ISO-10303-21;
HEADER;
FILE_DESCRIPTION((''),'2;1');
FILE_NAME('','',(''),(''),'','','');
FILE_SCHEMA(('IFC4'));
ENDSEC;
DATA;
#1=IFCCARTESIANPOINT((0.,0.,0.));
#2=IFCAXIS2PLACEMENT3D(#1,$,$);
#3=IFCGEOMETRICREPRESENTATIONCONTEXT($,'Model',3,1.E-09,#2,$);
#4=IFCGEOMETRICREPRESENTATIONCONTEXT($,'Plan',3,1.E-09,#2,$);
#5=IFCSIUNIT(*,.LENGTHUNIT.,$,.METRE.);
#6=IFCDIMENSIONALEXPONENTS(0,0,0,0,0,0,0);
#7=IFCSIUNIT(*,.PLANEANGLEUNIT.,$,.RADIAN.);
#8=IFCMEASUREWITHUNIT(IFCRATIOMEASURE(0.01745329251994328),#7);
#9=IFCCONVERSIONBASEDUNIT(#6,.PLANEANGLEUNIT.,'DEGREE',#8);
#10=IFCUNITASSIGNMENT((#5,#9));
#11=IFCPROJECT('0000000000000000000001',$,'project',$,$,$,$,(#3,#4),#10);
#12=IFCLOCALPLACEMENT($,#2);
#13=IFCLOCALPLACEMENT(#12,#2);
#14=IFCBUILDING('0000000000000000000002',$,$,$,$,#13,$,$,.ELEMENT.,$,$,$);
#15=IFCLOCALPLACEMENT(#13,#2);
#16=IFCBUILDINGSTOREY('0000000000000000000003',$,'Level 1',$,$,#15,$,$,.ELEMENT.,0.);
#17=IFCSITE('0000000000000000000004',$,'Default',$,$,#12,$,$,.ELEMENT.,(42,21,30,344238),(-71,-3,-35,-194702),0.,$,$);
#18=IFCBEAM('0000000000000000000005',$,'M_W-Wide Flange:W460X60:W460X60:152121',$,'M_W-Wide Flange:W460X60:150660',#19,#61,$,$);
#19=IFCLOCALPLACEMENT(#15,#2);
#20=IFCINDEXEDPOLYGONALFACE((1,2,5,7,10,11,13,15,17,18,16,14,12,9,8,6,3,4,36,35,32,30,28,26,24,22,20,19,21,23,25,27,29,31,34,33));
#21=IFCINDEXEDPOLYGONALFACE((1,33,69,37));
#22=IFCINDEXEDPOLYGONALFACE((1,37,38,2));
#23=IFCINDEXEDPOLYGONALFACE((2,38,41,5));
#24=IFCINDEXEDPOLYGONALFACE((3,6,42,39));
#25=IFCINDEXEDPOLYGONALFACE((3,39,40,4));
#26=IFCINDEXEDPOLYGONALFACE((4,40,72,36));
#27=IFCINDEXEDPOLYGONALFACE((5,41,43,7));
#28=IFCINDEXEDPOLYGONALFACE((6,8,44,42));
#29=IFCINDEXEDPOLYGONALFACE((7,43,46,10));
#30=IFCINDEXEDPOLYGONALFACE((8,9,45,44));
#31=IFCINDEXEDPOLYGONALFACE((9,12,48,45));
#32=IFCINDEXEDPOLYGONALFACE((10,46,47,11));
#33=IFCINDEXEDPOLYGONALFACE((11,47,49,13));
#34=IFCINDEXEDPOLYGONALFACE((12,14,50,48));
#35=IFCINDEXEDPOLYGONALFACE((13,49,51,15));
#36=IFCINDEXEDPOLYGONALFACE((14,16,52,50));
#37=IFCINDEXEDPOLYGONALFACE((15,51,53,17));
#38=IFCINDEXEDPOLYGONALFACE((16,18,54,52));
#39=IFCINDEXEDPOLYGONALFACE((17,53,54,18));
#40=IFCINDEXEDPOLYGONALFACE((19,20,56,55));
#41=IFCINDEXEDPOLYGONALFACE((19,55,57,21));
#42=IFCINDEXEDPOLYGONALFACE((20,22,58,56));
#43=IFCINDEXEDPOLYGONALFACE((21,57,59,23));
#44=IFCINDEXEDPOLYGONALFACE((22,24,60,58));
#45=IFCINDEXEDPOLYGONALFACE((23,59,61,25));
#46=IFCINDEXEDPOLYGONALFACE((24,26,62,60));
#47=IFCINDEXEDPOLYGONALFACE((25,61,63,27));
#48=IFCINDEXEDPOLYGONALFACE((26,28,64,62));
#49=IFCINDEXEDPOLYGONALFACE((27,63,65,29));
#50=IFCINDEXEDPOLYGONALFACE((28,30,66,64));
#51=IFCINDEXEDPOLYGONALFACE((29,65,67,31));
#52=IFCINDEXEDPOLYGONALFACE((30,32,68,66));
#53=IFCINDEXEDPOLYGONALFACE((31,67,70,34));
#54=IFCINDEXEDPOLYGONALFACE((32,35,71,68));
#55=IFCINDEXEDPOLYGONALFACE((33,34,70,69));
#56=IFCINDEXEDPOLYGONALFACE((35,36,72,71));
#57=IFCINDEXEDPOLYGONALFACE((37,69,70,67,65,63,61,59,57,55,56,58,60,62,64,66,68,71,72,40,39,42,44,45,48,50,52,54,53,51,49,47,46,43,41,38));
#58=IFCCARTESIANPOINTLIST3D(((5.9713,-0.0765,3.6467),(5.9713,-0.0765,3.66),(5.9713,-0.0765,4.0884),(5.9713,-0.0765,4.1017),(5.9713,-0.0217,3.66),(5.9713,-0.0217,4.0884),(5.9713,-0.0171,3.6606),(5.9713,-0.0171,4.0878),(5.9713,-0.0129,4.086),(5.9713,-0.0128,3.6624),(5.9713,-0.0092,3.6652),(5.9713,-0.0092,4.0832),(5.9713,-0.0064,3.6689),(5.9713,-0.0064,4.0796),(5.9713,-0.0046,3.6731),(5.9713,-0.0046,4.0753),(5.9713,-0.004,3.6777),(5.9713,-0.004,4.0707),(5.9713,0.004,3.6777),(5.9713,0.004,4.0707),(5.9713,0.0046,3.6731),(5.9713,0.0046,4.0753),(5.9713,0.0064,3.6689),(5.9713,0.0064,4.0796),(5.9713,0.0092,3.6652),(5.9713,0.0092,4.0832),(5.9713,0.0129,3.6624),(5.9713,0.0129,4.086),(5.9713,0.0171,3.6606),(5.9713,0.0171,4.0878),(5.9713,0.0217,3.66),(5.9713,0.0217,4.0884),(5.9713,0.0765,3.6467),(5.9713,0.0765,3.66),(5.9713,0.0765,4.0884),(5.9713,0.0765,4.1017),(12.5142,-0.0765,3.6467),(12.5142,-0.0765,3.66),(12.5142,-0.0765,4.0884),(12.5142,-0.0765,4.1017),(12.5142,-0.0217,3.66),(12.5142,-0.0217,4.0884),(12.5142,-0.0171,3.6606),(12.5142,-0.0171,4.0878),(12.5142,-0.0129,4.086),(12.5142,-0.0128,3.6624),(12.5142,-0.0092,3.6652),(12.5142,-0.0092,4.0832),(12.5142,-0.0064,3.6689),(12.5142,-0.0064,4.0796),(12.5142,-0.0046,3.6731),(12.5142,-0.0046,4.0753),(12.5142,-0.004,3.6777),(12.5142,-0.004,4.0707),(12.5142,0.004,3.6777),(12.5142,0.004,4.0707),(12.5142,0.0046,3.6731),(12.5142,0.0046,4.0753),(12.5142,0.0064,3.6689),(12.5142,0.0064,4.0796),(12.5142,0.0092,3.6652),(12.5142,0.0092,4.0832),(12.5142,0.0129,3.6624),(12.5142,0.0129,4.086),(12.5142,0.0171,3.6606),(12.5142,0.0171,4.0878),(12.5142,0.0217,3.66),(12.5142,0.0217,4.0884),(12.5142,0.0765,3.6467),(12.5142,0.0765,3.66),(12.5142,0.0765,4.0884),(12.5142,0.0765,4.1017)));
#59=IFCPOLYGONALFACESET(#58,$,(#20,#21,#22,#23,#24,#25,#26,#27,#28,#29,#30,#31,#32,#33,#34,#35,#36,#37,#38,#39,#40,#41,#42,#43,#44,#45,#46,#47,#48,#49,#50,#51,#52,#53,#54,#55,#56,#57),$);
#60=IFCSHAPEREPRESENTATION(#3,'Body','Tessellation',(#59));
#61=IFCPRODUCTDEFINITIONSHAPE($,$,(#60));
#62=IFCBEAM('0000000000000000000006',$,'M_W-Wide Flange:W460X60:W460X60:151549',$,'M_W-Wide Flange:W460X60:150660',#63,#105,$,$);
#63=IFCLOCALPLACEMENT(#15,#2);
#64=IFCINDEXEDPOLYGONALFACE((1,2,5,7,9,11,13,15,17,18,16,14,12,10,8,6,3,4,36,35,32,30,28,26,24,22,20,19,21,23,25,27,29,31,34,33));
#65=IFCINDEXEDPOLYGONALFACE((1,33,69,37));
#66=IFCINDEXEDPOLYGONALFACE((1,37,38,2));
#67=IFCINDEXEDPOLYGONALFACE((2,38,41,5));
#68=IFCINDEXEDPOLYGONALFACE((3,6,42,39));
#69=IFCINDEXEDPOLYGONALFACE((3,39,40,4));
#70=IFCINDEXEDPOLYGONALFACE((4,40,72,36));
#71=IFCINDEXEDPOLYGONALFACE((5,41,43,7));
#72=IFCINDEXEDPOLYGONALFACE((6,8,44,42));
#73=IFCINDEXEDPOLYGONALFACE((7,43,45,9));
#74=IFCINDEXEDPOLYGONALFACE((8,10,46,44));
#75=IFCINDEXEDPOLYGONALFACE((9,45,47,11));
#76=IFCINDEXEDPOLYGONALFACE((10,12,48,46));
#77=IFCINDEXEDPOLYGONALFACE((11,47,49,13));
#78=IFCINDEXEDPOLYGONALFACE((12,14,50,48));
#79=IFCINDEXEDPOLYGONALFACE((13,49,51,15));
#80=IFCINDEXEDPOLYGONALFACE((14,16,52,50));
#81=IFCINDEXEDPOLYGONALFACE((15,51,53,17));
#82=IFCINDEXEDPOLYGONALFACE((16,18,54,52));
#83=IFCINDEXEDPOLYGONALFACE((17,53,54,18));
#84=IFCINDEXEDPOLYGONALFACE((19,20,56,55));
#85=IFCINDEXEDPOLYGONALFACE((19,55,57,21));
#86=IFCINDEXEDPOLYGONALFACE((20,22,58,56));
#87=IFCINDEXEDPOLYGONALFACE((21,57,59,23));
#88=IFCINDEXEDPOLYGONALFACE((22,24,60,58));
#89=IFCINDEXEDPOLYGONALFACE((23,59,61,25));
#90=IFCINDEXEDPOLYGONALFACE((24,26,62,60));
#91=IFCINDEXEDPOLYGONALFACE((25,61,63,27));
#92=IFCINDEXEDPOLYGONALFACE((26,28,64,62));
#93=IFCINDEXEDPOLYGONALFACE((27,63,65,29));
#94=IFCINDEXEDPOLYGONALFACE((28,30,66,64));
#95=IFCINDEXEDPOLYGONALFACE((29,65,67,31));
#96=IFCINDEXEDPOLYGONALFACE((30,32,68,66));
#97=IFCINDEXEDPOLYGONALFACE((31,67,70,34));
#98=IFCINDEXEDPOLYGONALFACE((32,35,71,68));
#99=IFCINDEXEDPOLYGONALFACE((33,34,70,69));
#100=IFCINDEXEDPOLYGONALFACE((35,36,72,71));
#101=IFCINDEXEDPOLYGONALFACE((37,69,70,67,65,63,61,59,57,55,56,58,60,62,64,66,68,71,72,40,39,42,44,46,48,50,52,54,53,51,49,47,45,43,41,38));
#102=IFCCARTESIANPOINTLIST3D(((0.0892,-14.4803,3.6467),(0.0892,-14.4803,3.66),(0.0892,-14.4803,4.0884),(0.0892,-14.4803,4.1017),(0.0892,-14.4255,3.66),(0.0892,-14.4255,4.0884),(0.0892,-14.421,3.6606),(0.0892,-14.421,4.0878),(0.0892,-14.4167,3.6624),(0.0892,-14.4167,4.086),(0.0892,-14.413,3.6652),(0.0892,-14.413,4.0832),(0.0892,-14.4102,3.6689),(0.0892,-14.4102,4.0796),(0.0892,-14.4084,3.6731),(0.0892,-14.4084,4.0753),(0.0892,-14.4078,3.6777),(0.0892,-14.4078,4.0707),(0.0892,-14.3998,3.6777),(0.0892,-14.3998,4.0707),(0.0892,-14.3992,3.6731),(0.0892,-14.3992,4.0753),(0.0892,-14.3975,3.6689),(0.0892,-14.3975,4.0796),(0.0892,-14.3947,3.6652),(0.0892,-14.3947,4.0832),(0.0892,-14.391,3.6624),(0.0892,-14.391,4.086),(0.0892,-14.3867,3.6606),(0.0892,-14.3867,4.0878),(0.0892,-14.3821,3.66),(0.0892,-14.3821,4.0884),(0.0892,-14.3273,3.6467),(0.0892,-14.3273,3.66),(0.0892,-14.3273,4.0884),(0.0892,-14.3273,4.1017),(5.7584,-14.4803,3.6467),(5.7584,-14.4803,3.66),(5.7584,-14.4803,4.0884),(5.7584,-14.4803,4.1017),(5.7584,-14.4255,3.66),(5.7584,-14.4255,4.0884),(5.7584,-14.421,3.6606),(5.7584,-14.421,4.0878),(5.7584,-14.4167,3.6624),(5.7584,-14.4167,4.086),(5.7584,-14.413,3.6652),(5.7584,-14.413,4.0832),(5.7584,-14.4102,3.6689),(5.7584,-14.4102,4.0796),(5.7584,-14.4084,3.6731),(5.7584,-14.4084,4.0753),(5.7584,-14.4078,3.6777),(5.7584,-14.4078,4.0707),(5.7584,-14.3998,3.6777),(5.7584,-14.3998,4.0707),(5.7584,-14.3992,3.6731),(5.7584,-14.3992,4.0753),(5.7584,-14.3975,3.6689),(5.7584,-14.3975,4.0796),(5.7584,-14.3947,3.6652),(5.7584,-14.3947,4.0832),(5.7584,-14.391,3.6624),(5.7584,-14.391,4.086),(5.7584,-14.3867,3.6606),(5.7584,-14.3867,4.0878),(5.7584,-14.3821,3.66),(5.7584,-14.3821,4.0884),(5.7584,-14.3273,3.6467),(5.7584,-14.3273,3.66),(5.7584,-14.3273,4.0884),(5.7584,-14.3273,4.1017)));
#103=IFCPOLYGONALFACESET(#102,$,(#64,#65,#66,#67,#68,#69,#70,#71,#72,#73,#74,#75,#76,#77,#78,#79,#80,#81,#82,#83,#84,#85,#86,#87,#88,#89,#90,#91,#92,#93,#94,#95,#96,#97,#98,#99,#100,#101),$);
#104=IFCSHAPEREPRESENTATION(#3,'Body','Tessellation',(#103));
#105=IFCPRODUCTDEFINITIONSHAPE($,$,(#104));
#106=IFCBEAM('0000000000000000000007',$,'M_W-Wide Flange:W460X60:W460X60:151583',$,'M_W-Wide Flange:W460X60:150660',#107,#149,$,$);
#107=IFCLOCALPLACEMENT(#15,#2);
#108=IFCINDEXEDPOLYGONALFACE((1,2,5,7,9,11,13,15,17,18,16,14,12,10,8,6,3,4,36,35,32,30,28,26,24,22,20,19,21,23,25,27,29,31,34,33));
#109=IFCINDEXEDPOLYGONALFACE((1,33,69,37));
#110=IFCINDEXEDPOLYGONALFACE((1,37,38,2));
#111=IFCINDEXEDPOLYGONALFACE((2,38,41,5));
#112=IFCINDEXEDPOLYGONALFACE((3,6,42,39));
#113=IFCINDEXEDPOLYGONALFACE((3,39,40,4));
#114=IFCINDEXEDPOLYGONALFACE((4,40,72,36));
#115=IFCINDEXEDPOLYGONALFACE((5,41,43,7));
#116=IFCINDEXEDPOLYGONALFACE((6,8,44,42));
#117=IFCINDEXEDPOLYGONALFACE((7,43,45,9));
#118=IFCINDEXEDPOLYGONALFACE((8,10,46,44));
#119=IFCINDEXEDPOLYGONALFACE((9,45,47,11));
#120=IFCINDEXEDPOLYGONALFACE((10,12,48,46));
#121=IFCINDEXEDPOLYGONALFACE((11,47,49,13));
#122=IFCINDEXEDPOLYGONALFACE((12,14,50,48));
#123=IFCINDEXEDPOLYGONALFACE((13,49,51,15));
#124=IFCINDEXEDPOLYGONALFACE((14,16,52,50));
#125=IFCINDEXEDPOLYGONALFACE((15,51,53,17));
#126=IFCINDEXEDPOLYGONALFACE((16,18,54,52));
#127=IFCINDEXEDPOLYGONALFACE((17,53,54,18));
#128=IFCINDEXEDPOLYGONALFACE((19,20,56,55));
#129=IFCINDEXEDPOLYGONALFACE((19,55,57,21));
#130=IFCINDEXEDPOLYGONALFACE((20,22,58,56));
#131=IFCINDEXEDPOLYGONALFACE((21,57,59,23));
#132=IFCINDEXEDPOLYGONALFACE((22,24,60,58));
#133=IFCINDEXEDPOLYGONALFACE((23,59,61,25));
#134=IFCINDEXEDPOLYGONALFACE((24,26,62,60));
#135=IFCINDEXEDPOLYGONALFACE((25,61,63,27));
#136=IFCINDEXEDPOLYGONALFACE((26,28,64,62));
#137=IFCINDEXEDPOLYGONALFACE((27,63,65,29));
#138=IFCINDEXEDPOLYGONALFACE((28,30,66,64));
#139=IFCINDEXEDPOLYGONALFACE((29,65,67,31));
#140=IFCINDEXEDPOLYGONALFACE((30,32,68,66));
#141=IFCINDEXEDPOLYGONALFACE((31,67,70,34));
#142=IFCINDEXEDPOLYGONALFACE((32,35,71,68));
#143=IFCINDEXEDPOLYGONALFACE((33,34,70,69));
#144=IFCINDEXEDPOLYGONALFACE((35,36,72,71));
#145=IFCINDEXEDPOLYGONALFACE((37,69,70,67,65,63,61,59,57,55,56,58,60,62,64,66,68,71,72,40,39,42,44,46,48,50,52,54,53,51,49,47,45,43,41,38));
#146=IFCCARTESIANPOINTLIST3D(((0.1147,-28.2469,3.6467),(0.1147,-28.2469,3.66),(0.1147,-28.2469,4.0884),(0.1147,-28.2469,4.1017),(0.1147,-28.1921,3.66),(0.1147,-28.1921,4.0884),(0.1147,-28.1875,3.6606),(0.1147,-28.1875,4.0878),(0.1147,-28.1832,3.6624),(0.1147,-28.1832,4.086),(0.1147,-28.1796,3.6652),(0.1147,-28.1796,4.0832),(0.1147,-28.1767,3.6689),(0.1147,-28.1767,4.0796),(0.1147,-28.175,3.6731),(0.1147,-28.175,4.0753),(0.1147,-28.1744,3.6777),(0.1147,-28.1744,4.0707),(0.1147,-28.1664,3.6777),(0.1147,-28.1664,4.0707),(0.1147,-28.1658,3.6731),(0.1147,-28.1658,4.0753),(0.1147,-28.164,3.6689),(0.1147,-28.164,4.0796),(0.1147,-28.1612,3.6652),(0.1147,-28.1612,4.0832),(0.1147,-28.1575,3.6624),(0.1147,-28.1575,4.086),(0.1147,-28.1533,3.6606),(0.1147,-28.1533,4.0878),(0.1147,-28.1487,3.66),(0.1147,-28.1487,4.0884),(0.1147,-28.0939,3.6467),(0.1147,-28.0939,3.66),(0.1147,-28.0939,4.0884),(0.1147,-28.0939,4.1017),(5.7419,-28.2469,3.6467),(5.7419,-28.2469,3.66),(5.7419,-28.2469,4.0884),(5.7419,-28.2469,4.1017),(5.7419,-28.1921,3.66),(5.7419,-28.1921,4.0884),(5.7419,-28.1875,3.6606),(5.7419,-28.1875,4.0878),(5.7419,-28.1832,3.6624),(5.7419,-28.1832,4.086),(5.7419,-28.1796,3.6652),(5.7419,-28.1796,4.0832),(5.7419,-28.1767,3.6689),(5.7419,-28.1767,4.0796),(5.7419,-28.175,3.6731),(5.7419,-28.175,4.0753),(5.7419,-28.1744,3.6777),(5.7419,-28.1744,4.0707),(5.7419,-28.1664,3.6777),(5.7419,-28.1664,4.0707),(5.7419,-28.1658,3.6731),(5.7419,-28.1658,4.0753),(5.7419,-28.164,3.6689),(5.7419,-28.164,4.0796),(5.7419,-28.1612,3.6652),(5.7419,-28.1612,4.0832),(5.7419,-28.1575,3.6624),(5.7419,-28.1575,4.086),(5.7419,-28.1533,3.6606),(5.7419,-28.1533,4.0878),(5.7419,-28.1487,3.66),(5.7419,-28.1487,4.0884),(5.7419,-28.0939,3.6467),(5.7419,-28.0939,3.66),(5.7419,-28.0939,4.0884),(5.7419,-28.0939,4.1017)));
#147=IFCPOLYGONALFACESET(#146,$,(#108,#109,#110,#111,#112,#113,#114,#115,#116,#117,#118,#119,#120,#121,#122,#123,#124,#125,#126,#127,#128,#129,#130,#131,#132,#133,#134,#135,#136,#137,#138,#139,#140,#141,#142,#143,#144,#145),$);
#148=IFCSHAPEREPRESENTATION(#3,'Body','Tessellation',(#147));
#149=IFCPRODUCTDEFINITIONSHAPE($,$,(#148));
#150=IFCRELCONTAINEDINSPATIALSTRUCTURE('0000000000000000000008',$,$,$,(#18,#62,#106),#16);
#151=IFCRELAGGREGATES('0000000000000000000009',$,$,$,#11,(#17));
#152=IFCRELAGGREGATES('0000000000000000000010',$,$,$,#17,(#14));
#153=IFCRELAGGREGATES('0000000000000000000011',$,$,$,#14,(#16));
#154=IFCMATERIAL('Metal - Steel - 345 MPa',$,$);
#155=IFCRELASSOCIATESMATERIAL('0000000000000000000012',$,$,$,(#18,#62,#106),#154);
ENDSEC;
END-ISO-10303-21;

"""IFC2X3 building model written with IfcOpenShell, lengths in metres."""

from ifc_helpers import new_model, entity, si_unit, converted_unit, frame, frame_2d, origin, place, context, project, spatial, polyline, circle_curve, parameter, trimmed, segment, composite_curve, outline, extrude, material, element, save


model = new_model("IFC2X3")

# Units and contexts
model_context = context("Model", 3, precision=1e-09, world=origin())
plan_context = context("Plan", 3, precision=1e-09, world=origin())
ifc_project = project(units=[si_unit("LENGTHUNIT", "METRE"), converted_unit("PLANEANGLEUNIT", "DEGREE", entity("IfcRatioMeasure", 0.01745329251994328), si_unit("PLANEANGLEUNIT", "RADIAN"), dimensions=[0, 0, 0, 0, 0, 0, 0])], contexts=[model_context, plan_context])

# Site, building, storey
site_placement = place(None, origin())
site = spatial("IfcSite", under=ifc_project, at=site_placement, Name="Default", CompositionType="ELEMENT", RefLatitude=(42, 21, 30, 344238), RefLongitude=(-71, -3, -35, -194702), RefElevation=0.0)
building_placement = place(site_placement, origin())
building = spatial("IfcBuilding", under=site, at=building_placement, CompositionType="ELEMENT")
storey_placement = place(building_placement, origin())
storey = spatial("IfcBuildingStorey", under=building, at=storey_placement, Name="Level 1", CompositionType="ELEMENT", Elevation=0.0)

# Beams
ifc_material_1 = material(Name="Metal - Steel - 345 MPa")
beam_1_placement = place(storey_placement, frame((5.8566, 0.0, 4.2672), z_axis=(0.0, 0.0, 1.0), x_axis=(0.0, -1.0, 0.0)))
element("IfcBeam", 1, at=beam_1_placement, inside=storey, material=ifc_material_1, Name="M_W-Wide Flange:W460X60:W460X60:152121", ObjectType="M_W-Wide Flange:W460X60:150660", context=model_context, shape_type="SweptSolid", body=[
    extrude(outline(composite_curve([segment(polyline([(-0.0765, -0.2142), (-0.0765, -0.2275)]), True, "CONTINUOUS"), segment(polyline([(-0.0765, -0.2275), (0.0765, -0.2275)]), True, "CONTINUOUS"), segment(polyline([(0.0765, -0.2275), (0.0765, -0.2142)]), True, "CONTINUOUS"), segment(polyline([(0.0765, -0.2142), (0.0217, -0.2142)]), True, "CONTINUOUS"), segment(trimmed(circle_curve(frame_2d((0.0217, -0.1965), x_axis=(0.0, -1.0)), 0.0177), [parameter(270.0)], [parameter(360.0)], True, "PARAMETER"), False, "CONTINUOUS"), segment(polyline([(0.004, -0.1965), (0.004, 0.1965)]), True, "CONTINUOUS"), segment(trimmed(circle_curve(frame_2d((0.0217, 0.1965), x_axis=(-1.0, 0.0)), 0.0177), [parameter(270.0)], [parameter(360.0)], True, "PARAMETER"), False, "CONTINUOUS"), segment(polyline([(0.0217, 0.2142), (0.0765, 0.2142)]), True, "CONTINUOUS"), segment(polyline([(0.0765, 0.2142), (0.0765, 0.2275)]), True, "CONTINUOUS"), segment(polyline([(0.0765, 0.2275), (-0.0765, 0.2275)]), True, "CONTINUOUS"), segment(polyline([(-0.0765, 0.2275), (-0.0765, 0.2142)]), True, "CONTINUOUS"), segment(polyline([(-0.0765, 0.2142), (-0.0217, 0.2142)]), True, "CONTINUOUS"), segment(trimmed(circle_curve(frame_2d((-0.0217, 0.1965), x_axis=(0.0, 1.0)), 0.0177), [parameter(270.0)], [parameter(360.0)], True, "PARAMETER"), False, "CONTINUOUS"), segment(polyline([(-0.004, 0.1965), (-0.004, -0.1965)]), True, "CONTINUOUS"), segment(trimmed(circle_curve(frame_2d((-0.0217, -0.1965), x_axis=(1.0, 0.0)), 0.0177), [parameter(270.0)], [parameter(0.0)], True, "PARAMETER"), False, "CONTINUOUS"), segment(polyline([(-0.0217, -0.2142), (-0.0765, -0.2142)]), True, "CONTINUOUS")], self_intersect=False)), frame((0.0, 0.1147, -0.393), z_axis=(0.0, -1.0, 0.0), x_axis=(1.0, 0.0, 0.0)), (0.0, 0.0, -1.0), 6.5429),
])
beam_2_placement = place(storey_placement, frame((5.8566, -14.4038, 4.2672), z_axis=(0.0, 0.0, 1.0), x_axis=(0.0, 1.0, 0.0)))
element("IfcBeam", 2, at=beam_2_placement, inside=storey, material=ifc_material_1, Name="M_W-Wide Flange:W460X60:W460X60:151549", ObjectType="M_W-Wide Flange:W460X60:150660", context=model_context, shape_type="SweptSolid", body=[
    extrude(outline(composite_curve([segment(polyline([(0.2142, -0.0765), (0.2275, -0.0765)]), True, "CONTINUOUS"), segment(polyline([(0.2275, -0.0765), (0.2275, 0.0765)]), True, "CONTINUOUS"), segment(polyline([(0.2275, 0.0765), (0.2142, 0.0765)]), True, "CONTINUOUS"), segment(polyline([(0.2142, 0.0765), (0.2142, 0.0217)]), True, "CONTINUOUS"), segment(trimmed(circle_curve(frame_2d((0.1965, 0.0217), x_axis=(0.0, 1.0)), 0.0177), [parameter(180.0)], [parameter(270.0)], True, "PARAMETER"), False, "CONTINUOUS"), segment(polyline([(0.1965, 0.004), (-0.1965, 0.004)]), True, "CONTINUOUS"), segment(trimmed(circle_curve(frame_2d((-0.1965, 0.0217), x_axis=(0.0, 1.0)), 0.0177), [parameter(90.0)], [parameter(180.0)], True, "PARAMETER"), False, "CONTINUOUS"), segment(polyline([(-0.2142, 0.0217), (-0.2142, 0.0765)]), True, "CONTINUOUS"), segment(polyline([(-0.2142, 0.0765), (-0.2275, 0.0765)]), True, "CONTINUOUS"), segment(polyline([(-0.2275, 0.0765), (-0.2275, -0.0765)]), True, "CONTINUOUS"), segment(polyline([(-0.2275, -0.0765), (-0.2142, -0.0765)]), True, "CONTINUOUS"), segment(polyline([(-0.2142, -0.0765), (-0.2142, -0.0217)]), True, "CONTINUOUS"), segment(trimmed(circle_curve(frame_2d((-0.1965, -0.0217), x_axis=(0.0, 1.0)), 0.0177), [parameter(360.0)], [parameter(90.0)], True, "PARAMETER"), False, "CONTINUOUS"), segment(polyline([(-0.1965, -0.004), (0.1965, -0.004)]), True, "CONTINUOUS"), segment(trimmed(circle_curve(frame_2d((0.1965, -0.0217), x_axis=(0.0, 1.0)), 0.0177), [parameter(270.0)], [parameter(0.0)], True, "PARAMETER"), False, "CONTINUOUS"), segment(polyline([(0.2142, -0.0217), (0.2142, -0.0765)]), True, "CONTINUOUS")], self_intersect=False)), frame((0.0, 5.7674, -0.393), z_axis=(0.0, -1.0, 0.0), x_axis=(0.0, 0.0, -1.0)), (0.0, 0.0, 1.0), 5.6692),
])
beam_3_placement = place(storey_placement, frame((0.0, -28.1704, 4.2672), z_axis=(0.0, 0.0, 1.0), x_axis=(0.0, -1.0, 0.0)))
element("IfcBeam", 3, at=beam_3_placement, inside=storey, material=ifc_material_1, Name="M_W-Wide Flange:W460X60:W460X60:151583", ObjectType="M_W-Wide Flange:W460X60:150660", context=model_context, shape_type="SweptSolid", body=[
    extrude(outline(composite_curve([segment(polyline([(-0.0765, -0.2142), (-0.0765, -0.2275)]), True, "CONTINUOUS"), segment(polyline([(-0.0765, -0.2275), (0.0765, -0.2275)]), True, "CONTINUOUS"), segment(polyline([(0.0765, -0.2275), (0.0765, -0.2142)]), True, "CONTINUOUS"), segment(polyline([(0.0765, -0.2142), (0.0217, -0.2142)]), True, "CONTINUOUS"), segment(trimmed(circle_curve(frame_2d((0.0217, -0.1965), x_axis=(0.0, -1.0)), 0.0177), [parameter(270.0)], [parameter(360.0)], True, "PARAMETER"), False, "CONTINUOUS"), segment(polyline([(0.004, -0.1965), (0.004, 0.1965)]), True, "CONTINUOUS"), segment(trimmed(circle_curve(frame_2d((0.0217, 0.1965), x_axis=(-1.0, 0.0)), 0.0177), [parameter(270.0)], [parameter(360.0)], True, "PARAMETER"), False, "CONTINUOUS"), segment(polyline([(0.0217, 0.2142), (0.0765, 0.2142)]), True, "CONTINUOUS"), segment(polyline([(0.0765, 0.2142), (0.0765, 0.2275)]), True, "CONTINUOUS"), segment(polyline([(0.0765, 0.2275), (-0.0765, 0.2275)]), True, "CONTINUOUS"), segment(polyline([(-0.0765, 0.2275), (-0.0765, 0.2142)]), True, "CONTINUOUS"), segment(polyline([(-0.0765, 0.2142), (-0.0217, 0.2142)]), True, "CONTINUOUS"), segment(trimmed(circle_curve(frame_2d((-0.0217, 0.1965), x_axis=(0.0, 1.0)), 0.0177), [parameter(270.0)], [parameter(360.0)], True, "PARAMETER"), False, "CONTINUOUS"), segment(polyline([(-0.004, 0.1965), (-0.004, -0.1965)]), True, "CONTINUOUS"), segment(trimmed(circle_curve(frame_2d((-0.0217, -0.1965), x_axis=(1.0, 0.0)), 0.0177), [parameter(270.0)], [parameter(0.0)], True, "PARAMETER"), False, "CONTINUOUS"), segment(polyline([(-0.0217, -0.2142), (-0.0765, -0.2142)]), True, "CONTINUOUS")], self_intersect=False)), frame((0.0, 0.1147, -0.393), z_axis=(0.0, -1.0, 0.0), x_axis=(1.0, 0.0, 0.0)), (0.0, 0.0, -1.0), 5.6272),
])

save(model, "model.ifc")
